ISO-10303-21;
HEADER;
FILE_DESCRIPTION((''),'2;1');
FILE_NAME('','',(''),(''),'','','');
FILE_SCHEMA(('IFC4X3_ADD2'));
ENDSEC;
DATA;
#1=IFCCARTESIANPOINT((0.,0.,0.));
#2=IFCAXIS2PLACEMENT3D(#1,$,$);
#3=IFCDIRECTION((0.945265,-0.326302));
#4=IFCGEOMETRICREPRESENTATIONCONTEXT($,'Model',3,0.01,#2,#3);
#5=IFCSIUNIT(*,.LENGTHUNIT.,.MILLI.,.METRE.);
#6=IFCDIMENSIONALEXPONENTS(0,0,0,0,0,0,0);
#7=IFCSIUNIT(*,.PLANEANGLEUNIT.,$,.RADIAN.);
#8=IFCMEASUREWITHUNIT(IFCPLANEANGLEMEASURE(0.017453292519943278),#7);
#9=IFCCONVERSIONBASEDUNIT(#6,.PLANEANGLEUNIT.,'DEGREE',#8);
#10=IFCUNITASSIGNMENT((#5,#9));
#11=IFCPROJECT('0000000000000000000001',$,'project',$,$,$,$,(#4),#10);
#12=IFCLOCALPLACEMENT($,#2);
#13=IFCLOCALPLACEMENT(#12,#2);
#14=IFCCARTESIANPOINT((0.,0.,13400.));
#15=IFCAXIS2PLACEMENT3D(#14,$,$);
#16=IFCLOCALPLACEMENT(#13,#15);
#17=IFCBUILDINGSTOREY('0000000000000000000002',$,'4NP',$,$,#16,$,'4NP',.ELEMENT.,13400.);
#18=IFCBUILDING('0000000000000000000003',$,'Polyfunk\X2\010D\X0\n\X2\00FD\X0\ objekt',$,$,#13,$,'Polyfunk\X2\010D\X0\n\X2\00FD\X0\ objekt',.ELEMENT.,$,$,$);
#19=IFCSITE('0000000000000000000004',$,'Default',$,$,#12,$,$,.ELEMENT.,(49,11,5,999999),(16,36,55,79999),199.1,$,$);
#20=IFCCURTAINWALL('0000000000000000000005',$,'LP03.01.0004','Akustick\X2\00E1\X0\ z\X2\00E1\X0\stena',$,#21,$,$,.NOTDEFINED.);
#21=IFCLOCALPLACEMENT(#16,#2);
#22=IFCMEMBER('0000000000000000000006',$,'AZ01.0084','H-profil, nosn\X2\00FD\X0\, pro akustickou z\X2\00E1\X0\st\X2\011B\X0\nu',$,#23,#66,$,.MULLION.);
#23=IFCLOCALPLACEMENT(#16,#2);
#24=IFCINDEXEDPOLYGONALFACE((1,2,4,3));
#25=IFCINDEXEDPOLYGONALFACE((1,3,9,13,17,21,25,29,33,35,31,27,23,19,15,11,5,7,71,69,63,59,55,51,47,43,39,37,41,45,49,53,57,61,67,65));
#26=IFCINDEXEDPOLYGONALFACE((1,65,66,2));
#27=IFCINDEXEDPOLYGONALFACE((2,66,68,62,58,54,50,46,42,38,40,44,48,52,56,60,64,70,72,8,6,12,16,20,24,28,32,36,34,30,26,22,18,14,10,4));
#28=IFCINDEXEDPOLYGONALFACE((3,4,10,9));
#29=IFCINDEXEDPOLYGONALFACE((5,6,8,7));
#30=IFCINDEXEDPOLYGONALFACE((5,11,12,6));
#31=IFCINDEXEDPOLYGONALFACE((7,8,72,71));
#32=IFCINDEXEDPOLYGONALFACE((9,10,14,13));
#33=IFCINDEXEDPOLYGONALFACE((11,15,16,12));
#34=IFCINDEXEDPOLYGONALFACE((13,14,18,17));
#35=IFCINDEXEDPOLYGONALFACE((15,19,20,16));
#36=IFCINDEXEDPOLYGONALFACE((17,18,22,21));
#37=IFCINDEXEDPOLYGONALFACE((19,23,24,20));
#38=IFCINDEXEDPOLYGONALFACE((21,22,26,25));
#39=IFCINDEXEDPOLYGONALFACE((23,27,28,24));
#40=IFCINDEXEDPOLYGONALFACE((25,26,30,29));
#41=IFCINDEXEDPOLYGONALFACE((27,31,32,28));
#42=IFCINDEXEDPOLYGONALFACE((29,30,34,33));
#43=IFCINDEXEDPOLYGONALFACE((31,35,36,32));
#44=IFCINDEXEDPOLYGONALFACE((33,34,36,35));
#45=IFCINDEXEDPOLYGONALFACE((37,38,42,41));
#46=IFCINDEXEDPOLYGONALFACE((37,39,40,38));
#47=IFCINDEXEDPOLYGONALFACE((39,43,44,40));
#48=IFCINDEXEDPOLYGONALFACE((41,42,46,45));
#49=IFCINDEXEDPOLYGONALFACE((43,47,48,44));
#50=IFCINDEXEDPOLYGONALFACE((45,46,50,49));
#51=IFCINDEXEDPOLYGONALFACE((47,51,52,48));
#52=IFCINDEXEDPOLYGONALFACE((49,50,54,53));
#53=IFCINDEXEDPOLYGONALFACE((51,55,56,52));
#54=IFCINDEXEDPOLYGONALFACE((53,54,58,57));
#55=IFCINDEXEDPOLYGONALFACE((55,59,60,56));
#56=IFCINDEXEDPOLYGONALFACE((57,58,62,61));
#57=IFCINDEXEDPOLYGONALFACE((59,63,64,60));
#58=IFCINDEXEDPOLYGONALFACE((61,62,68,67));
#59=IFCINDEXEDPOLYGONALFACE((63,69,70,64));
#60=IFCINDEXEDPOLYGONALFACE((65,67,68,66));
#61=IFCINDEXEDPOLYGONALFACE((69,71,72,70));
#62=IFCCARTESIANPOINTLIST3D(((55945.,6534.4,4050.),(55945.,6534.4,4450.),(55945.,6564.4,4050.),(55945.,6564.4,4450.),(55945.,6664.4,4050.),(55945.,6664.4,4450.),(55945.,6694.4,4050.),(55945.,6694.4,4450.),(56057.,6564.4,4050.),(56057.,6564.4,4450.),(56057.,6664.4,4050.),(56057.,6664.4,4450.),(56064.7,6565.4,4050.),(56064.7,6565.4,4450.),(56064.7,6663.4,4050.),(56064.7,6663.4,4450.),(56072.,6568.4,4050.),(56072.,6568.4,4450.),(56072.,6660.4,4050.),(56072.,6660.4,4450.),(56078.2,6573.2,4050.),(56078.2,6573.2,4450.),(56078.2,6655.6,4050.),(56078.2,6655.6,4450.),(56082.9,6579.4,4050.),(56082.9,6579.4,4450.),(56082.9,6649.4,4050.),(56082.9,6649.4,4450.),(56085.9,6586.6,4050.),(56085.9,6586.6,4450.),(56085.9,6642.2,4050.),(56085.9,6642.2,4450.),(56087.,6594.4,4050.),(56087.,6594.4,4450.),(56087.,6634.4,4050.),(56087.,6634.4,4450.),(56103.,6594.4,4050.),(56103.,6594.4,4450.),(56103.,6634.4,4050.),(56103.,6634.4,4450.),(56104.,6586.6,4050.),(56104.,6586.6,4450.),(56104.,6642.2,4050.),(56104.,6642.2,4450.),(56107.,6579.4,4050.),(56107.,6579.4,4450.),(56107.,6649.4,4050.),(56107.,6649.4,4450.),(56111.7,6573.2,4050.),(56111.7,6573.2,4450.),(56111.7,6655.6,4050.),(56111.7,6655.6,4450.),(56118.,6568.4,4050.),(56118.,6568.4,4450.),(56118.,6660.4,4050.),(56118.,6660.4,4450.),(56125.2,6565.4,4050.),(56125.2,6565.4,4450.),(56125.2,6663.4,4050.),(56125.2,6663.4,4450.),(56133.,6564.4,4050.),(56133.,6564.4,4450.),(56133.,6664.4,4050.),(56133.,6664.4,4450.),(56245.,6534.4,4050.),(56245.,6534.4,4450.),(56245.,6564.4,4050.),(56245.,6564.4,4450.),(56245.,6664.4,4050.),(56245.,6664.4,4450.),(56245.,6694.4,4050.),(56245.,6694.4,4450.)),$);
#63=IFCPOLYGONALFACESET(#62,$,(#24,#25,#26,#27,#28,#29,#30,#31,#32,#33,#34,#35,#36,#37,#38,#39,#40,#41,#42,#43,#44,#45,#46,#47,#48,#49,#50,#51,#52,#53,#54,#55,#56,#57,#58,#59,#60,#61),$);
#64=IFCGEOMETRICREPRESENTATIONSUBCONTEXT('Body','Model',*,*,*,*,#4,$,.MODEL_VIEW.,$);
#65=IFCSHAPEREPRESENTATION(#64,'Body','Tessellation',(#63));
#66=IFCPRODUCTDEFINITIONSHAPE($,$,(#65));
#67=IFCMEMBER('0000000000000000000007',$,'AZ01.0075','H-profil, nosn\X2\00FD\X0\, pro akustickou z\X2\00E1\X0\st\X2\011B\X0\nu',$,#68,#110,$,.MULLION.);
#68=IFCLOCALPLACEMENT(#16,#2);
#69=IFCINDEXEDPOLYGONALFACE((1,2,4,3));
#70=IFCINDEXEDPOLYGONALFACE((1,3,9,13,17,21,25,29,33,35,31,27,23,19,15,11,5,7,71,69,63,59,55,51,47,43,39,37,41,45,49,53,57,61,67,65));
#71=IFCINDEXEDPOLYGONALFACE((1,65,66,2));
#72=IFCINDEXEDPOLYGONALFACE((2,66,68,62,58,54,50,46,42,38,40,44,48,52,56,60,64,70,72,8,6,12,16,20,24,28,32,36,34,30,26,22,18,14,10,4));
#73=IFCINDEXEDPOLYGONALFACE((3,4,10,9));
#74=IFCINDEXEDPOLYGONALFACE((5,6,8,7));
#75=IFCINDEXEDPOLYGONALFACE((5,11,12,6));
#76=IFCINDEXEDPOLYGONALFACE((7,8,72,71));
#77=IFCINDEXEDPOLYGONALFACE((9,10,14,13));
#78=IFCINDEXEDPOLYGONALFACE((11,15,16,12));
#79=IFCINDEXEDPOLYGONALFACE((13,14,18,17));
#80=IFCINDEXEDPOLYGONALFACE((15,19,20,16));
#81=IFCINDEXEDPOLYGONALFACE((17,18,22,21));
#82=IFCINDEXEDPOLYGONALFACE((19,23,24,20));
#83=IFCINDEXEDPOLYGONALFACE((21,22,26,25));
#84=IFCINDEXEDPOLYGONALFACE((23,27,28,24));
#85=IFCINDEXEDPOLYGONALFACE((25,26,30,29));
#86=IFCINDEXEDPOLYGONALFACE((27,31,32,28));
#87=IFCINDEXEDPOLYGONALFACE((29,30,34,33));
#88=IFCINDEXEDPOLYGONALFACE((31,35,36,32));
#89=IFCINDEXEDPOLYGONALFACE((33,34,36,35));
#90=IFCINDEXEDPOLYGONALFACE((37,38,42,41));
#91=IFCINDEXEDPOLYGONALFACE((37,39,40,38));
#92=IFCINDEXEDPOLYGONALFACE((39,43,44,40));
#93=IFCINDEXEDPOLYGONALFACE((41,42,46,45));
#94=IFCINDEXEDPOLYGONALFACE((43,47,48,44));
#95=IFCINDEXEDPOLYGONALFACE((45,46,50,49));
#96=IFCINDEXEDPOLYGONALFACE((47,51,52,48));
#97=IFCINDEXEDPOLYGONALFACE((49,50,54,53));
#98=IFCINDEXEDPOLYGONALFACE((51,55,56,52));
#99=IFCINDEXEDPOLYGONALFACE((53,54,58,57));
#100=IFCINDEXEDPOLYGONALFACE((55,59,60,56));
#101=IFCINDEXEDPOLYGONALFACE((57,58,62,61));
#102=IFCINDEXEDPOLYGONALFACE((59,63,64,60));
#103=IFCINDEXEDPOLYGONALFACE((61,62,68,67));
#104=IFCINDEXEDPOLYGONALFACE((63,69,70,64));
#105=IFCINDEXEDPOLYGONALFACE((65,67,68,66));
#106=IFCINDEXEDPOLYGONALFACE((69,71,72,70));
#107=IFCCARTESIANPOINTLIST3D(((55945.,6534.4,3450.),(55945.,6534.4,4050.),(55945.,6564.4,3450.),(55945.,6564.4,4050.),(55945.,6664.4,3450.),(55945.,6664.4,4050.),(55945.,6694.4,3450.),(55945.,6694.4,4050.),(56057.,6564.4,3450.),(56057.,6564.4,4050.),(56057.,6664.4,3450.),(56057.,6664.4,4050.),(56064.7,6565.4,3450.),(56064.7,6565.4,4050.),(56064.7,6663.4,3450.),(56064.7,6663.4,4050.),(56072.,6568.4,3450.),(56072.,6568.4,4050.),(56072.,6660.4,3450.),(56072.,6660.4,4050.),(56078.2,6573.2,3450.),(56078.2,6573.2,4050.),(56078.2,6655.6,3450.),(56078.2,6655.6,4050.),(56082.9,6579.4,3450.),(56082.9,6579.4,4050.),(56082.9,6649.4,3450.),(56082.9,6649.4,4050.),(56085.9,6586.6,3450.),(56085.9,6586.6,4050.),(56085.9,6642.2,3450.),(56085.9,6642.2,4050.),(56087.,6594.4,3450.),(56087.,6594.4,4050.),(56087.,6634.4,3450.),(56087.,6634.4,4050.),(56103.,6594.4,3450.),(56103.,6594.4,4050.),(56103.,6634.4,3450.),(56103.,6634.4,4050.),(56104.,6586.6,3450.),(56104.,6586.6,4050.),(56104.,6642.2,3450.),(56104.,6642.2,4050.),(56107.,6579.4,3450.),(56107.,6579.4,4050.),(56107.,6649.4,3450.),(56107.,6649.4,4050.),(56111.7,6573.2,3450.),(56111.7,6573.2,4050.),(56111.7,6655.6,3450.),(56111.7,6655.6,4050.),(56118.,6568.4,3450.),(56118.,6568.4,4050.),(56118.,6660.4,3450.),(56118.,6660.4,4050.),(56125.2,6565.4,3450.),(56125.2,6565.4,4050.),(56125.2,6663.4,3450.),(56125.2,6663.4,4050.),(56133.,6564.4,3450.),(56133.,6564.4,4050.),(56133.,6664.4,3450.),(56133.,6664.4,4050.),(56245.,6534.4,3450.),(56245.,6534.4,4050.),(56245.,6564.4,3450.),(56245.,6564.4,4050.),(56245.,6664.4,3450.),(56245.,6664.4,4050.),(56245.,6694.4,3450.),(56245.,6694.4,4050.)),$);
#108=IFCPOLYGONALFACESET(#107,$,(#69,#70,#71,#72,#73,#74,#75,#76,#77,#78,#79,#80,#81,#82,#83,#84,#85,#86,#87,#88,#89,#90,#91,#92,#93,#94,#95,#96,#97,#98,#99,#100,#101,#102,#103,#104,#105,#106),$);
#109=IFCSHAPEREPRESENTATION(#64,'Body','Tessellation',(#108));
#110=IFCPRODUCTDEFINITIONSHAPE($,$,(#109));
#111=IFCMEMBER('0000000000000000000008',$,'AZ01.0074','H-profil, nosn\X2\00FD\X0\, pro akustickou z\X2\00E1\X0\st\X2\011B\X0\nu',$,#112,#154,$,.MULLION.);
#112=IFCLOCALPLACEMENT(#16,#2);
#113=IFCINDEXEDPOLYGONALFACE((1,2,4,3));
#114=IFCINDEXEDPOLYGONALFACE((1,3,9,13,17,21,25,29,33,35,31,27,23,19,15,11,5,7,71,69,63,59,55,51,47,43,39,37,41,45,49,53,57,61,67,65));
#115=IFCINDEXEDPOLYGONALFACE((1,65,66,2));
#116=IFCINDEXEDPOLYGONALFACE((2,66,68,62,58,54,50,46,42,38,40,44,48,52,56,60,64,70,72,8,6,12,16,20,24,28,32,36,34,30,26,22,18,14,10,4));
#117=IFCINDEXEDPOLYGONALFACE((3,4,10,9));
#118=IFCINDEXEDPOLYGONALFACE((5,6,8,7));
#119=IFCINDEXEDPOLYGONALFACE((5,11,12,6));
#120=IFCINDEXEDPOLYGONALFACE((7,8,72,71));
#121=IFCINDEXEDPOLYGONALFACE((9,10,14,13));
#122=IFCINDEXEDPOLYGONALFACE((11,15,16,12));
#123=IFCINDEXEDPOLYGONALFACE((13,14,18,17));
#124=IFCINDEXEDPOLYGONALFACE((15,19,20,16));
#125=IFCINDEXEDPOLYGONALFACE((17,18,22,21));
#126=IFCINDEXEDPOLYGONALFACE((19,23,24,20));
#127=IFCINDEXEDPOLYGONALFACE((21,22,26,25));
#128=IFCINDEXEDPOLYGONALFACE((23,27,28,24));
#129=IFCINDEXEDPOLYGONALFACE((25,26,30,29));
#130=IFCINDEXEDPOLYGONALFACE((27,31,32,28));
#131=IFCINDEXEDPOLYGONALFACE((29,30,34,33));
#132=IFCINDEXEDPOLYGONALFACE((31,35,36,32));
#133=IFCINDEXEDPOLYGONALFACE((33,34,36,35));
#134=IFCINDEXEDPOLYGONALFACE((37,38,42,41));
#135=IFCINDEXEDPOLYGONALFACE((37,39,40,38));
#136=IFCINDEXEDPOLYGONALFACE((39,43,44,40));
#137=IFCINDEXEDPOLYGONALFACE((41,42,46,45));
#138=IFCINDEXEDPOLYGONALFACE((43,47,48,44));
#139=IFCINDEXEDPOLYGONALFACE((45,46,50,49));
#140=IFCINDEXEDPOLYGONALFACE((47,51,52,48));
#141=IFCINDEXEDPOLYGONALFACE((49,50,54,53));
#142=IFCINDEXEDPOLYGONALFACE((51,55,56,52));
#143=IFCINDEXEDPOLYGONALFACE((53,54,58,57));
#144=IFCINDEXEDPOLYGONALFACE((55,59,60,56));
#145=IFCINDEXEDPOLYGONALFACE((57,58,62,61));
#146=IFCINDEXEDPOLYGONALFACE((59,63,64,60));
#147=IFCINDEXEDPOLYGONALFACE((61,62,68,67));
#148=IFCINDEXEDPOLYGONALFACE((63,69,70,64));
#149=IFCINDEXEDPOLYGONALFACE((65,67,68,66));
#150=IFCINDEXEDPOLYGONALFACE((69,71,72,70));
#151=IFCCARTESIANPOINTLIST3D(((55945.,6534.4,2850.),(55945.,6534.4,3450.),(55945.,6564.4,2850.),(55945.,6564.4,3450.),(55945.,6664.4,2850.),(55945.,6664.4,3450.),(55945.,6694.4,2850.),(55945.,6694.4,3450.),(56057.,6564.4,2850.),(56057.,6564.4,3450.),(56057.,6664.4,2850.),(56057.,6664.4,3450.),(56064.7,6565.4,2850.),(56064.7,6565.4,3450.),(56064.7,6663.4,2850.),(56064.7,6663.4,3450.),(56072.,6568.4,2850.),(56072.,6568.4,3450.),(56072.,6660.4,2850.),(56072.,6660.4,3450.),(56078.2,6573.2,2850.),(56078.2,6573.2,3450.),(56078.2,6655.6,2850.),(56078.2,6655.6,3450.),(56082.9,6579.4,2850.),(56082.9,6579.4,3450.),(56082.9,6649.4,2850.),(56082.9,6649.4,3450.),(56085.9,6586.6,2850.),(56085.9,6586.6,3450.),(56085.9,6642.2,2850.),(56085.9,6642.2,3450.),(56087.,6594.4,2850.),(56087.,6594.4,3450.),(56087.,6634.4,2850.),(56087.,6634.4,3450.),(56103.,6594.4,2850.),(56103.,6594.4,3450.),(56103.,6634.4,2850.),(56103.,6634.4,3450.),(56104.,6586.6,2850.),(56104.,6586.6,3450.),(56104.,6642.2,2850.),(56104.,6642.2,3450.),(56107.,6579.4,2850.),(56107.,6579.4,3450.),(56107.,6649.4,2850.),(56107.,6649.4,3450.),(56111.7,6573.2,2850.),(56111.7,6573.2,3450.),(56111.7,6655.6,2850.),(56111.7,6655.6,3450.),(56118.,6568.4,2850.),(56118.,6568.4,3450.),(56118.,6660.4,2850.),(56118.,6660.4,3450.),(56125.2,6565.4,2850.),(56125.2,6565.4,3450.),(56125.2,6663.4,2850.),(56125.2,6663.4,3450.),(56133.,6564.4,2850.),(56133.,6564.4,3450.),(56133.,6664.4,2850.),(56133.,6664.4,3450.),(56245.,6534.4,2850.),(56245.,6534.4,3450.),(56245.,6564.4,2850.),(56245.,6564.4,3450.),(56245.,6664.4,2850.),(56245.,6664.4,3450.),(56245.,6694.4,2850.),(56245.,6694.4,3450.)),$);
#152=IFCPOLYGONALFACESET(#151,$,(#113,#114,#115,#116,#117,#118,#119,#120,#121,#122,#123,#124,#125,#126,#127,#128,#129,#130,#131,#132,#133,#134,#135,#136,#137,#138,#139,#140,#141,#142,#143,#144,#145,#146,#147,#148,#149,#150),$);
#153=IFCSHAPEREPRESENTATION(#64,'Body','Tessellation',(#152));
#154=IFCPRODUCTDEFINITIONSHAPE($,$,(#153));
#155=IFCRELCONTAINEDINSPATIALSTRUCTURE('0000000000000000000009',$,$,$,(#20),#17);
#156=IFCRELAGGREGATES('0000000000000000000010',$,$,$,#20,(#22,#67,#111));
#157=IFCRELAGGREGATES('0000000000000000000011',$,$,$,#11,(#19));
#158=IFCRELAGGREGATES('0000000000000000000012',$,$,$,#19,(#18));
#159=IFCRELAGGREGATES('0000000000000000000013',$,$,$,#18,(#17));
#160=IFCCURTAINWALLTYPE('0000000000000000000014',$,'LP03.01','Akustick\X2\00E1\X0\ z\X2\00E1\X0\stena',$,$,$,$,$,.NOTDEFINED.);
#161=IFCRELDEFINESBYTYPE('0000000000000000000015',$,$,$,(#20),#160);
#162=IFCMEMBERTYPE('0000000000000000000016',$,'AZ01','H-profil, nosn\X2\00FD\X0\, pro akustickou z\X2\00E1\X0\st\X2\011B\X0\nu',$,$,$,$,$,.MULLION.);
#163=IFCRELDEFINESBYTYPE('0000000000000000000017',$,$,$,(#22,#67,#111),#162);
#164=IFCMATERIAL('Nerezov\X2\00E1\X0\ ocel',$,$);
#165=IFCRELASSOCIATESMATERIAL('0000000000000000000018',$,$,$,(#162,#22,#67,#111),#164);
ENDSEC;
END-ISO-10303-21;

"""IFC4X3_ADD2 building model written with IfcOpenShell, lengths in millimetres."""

from ifc_helpers import new_model, entity, si_unit, converted_unit, direction, frame, frame_2d, origin, place, context, subcontext, project, spatial, polyline, circle_curve, parameter, trimmed, segment, composite_curve, outline, extrude, source, transform, mapped, material, material_profile, profile_set, profile_usage, type_object, element, aggregate, save


model = new_model("IFC4X3_ADD2")

# Units and contexts
model_context = context("Model", 3, precision=0.01, world=origin(), true_north=direction((0.945265, -0.326302)))
body_context = subcontext(model_context, "Body", "Model", "MODEL_VIEW")
ifc_project = project(units=[si_unit("LENGTHUNIT", "METRE", prefix="MILLI"), converted_unit("PLANEANGLEUNIT", "DEGREE", entity("IfcPlaneAngleMeasure", 0.017453292519943278), si_unit("PLANEANGLEUNIT", "RADIAN"), dimensions=[0, 0, 0, 0, 0, 0, 0])], contexts=[model_context])

# Site, building, storey
site_placement = place(None, origin())
site = spatial("IfcSite", under=ifc_project, at=site_placement, Name="Default", CompositionType="ELEMENT", RefLatitude=(49, 11, 5, 999999), RefLongitude=(16, 36, 55, 79999), RefElevation=199.1)
building_placement = place(site_placement, origin())
building = spatial("IfcBuilding", under=site, at=building_placement, Name="Polyfunkčný objekt", LongName="Polyfunkčný objekt", CompositionType="ELEMENT")
storey_placement = place(building_placement, frame((0.0, 0.0, 13400.0)))
storey = spatial("IfcBuildingStorey", under=building, at=storey_placement, Name="4NP", LongName="4NP", CompositionType="ELEMENT", Elevation=13400.0)

# Curtain wall, members
curtain_wall_type = type_object("IfcCurtainWallType", Name="LP03.01", Description="Akustická zástena", PredefinedType="NOTDEFINED")
curtain_wall_1_placement = place(storey_placement, frame((0.0, 0.0, -13400.0)))
curtain_wall_1 = element("IfcCurtainWall", 1, at=curtain_wall_1_placement, inside=storey, type_object=curtain_wall_type, Name="LP03.01.0004", Description="Akustická zástena", PredefinedType="NOTDEFINED")
ifc_material_1 = material(Name="Nerezová ocel")
ifc_material_profile = material_profile(ifc_material_1, outline(composite_curve([segment(polyline([(50.0, -150.0), (80.0, -150.0)]), True, "CONTINUOUS"), segment(polyline([(80.0, -150.0), (80.0, 150.0)]), True, "CONTINUOUS"), segment(polyline([(80.0, 150.0), (50.0, 150.0)]), True, "CONTINUOUS"), segment(polyline([(50.0, 150.0), (50.0, 38.0)]), True, "CONTINUOUS"), segment(trimmed(circle_curve(frame_2d((20.0, 38.0), x_axis=(0.0, 1.0)), 30.0), [parameter(180.0)], [parameter(270.0)], True, "PARAMETER"), False, "CONTINUOUS"), segment(polyline([(20.0, 8.0), (-20.0, 8.0)]), True, "CONTINUOUS"), segment(trimmed(circle_curve(frame_2d((-20.0, 38.0), x_axis=(0.0, 1.0)), 30.0), [parameter(90.0)], [parameter(180.0)], True, "PARAMETER"), False, "CONTINUOUS"), segment(polyline([(-50.0, 38.0), (-50.0, 150.0)]), True, "CONTINUOUS"), segment(polyline([(-50.0, 150.0), (-80.0, 150.0)]), True, "CONTINUOUS"), segment(polyline([(-80.0, 150.0), (-80.0, -150.0)]), True, "CONTINUOUS"), segment(polyline([(-80.0, -150.0), (-50.0, -150.0)]), True, "CONTINUOUS"), segment(polyline([(-50.0, -150.0), (-50.0, -38.0)]), True, "CONTINUOUS"), segment(trimmed(circle_curve(frame_2d((-20.0, -38.0), x_axis=(0.0, 1.0)), 30.0), [parameter(0.0)], [parameter(90.0)], True, "PARAMETER"), False, "CONTINUOUS"), segment(polyline([(-20.0, -8.0), (20.0, -8.0)]), True, "CONTINUOUS"), segment(trimmed(circle_curve(frame_2d((20.0, -38.0), x_axis=(0.0, 1.0)), 30.0), [parameter(270.0)], [parameter(0.0)], True, "PARAMETER"), False, "CONTINUOUS"), segment(polyline([(50.0, -38.0), (50.0, -150.0)]), True, "CONTINUOUS")], self_intersect=False)), Name="Profil zástena")
ifc_profile_set = profile_set([ifc_material_profile], Name="Profil zástena")
ifc_profile_usage = profile_usage(ifc_profile_set)
member_type = type_object("IfcMemberType", Name="AZ01", Description="H-profil, nosný, pro akustickou zástěnu", PredefinedType="MULLION", material=ifc_profile_set)
shared_shape_1 = source(origin(), body_context, "Body", "SweptSolid", [
    extrude(outline(composite_curve([segment(polyline([(50.0, -150.0), (80.0, -150.0)]), True, "CONTINUOUS"), segment(polyline([(80.0, -150.0), (80.0, 150.0)]), True, "CONTINUOUS"), segment(polyline([(80.0, 150.0), (50.0, 150.0)]), True, "CONTINUOUS"), segment(polyline([(50.0, 150.0), (50.0, 38.0)]), True, "CONTINUOUS"), segment(trimmed(circle_curve(frame_2d((20.0, 38.0), x_axis=(0.0, 1.0)), 30.0), [parameter(180.0)], [parameter(270.0)], True, "PARAMETER"), False, "CONTINUOUS"), segment(polyline([(20.0, 8.0), (-20.0, 8.0)]), True, "CONTINUOUS"), segment(trimmed(circle_curve(frame_2d((-20.0, 38.0), x_axis=(0.0, 1.0)), 30.0), [parameter(90.0)], [parameter(180.0)], True, "PARAMETER"), False, "CONTINUOUS"), segment(polyline([(-50.0, 38.0), (-50.0, 150.0)]), True, "CONTINUOUS"), segment(polyline([(-50.0, 150.0), (-80.0, 150.0)]), True, "CONTINUOUS"), segment(polyline([(-80.0, 150.0), (-80.0, -150.0)]), True, "CONTINUOUS"), segment(polyline([(-80.0, -150.0), (-50.0, -150.0)]), True, "CONTINUOUS"), segment(polyline([(-50.0, -150.0), (-50.0, -38.0)]), True, "CONTINUOUS"), segment(trimmed(circle_curve(frame_2d((-20.0, -38.0), x_axis=(0.0, 1.0)), 30.0), [parameter(0.0)], [parameter(90.0)], True, "PARAMETER"), False, "CONTINUOUS"), segment(polyline([(-20.0, -8.0), (20.0, -8.0)]), True, "CONTINUOUS"), segment(trimmed(circle_curve(frame_2d((20.0, -38.0), x_axis=(0.0, 1.0)), 30.0), [parameter(270.0)], [parameter(0.0)], True, "PARAMETER"), False, "CONTINUOUS"), segment(polyline([(50.0, -38.0), (50.0, -150.0)]), True, "CONTINUOUS")], self_intersect=False)), frame((-150.0, 0.0, -400.0), z_axis=(0.0, 0.0, 1.0), x_axis=(0.0, -1.0, 0.0)), (0.0, 0.0, 1.0), 400.0),
])
member_1_placement = place(curtain_wall_1_placement, frame((56245.0, 6614.4, 17450.0), z_axis=(0.0, 0.0, -1.0), x_axis=(1.0, 0.0, 0.0)))
member_1 = element("IfcMember", 2, at=member_1_placement, type_object=member_type, material=ifc_profile_usage, Name="AZ01.0084", Description="H-profil, nosný, pro akustickou zástěnu", PredefinedType="MULLION", context=body_context, shape_type="MappedRepresentation", body=[
    mapped(shared_shape_1, transform((0.0, 0.0, 0.0), scale=1.0)),
])
shared_shape_2 = source(origin(), body_context, "Body", "SweptSolid", [
    extrude(outline(composite_curve([segment(polyline([(50.0, -150.0), (80.0, -150.0)]), True, "CONTINUOUS"), segment(polyline([(80.0, -150.0), (80.0, 150.0)]), True, "CONTINUOUS"), segment(polyline([(80.0, 150.0), (50.0, 150.0)]), True, "CONTINUOUS"), segment(polyline([(50.0, 150.0), (50.0, 38.0)]), True, "CONTINUOUS"), segment(trimmed(circle_curve(frame_2d((20.0, 38.0), x_axis=(0.0, 1.0)), 30.0), [parameter(180.0)], [parameter(270.0)], True, "PARAMETER"), False, "CONTINUOUS"), segment(polyline([(20.0, 8.0), (-20.0, 8.0)]), True, "CONTINUOUS"), segment(trimmed(circle_curve(frame_2d((-20.0, 38.0), x_axis=(0.0, 1.0)), 30.0), [parameter(90.0)], [parameter(180.0)], True, "PARAMETER"), False, "CONTINUOUS"), segment(polyline([(-50.0, 38.0), (-50.0, 150.0)]), True, "CONTINUOUS"), segment(polyline([(-50.0, 150.0), (-80.0, 150.0)]), True, "CONTINUOUS"), segment(polyline([(-80.0, 150.0), (-80.0, -150.0)]), True, "CONTINUOUS"), segment(polyline([(-80.0, -150.0), (-50.0, -150.0)]), True, "CONTINUOUS"), segment(polyline([(-50.0, -150.0), (-50.0, -38.0)]), True, "CONTINUOUS"), segment(trimmed(circle_curve(frame_2d((-20.0, -38.0), x_axis=(0.0, 1.0)), 30.0), [parameter(0.0)], [parameter(90.0)], True, "PARAMETER"), False, "CONTINUOUS"), segment(polyline([(-20.0, -8.0), (20.0, -8.0)]), True, "CONTINUOUS"), segment(trimmed(circle_curve(frame_2d((20.0, -38.0), x_axis=(0.0, 1.0)), 30.0), [parameter(270.0)], [parameter(0.0)], True, "PARAMETER"), False, "CONTINUOUS"), segment(polyline([(50.0, -38.0), (50.0, -150.0)]), True, "CONTINUOUS")], self_intersect=False)), frame((-150.0, 0.0, -600.0), z_axis=(0.0, 0.0, 1.0), x_axis=(0.0, -1.0, 0.0)), (0.0, 0.0, 1.0), 600.0),
])
member_2_placement = place(curtain_wall_1_placement, frame((56245.0, 6614.4, 16850.0), z_axis=(0.0, 0.0, -1.0), x_axis=(1.0, 0.0, 0.0)))
member_2 = element("IfcMember", 3, at=member_2_placement, type_object=member_type, material=ifc_profile_usage, Name="AZ01.0075", Description="H-profil, nosný, pro akustickou zástěnu", PredefinedType="MULLION", context=body_context, shape_type="MappedRepresentation", body=[
    mapped(shared_shape_2, transform((0.0, 0.0, 0.0), scale=1.0)),
])
member_3_placement = place(curtain_wall_1_placement, frame((56245.0, 6614.4, 16250.0), z_axis=(0.0, 0.0, -1.0), x_axis=(1.0, 0.0, 0.0)))
member_3 = element("IfcMember", 4, at=member_3_placement, type_object=member_type, material=ifc_profile_usage, Name="AZ01.0074", Description="H-profil, nosný, pro akustickou zástěnu", PredefinedType="MULLION", context=body_context, shape_type="MappedRepresentation", body=[
    mapped(shared_shape_2, transform((0.0, 0.0, 0.0), scale=1.0)),
])
aggregate(curtain_wall_1, [member_1, member_2, member_3])

save(model, "model.ifc")
